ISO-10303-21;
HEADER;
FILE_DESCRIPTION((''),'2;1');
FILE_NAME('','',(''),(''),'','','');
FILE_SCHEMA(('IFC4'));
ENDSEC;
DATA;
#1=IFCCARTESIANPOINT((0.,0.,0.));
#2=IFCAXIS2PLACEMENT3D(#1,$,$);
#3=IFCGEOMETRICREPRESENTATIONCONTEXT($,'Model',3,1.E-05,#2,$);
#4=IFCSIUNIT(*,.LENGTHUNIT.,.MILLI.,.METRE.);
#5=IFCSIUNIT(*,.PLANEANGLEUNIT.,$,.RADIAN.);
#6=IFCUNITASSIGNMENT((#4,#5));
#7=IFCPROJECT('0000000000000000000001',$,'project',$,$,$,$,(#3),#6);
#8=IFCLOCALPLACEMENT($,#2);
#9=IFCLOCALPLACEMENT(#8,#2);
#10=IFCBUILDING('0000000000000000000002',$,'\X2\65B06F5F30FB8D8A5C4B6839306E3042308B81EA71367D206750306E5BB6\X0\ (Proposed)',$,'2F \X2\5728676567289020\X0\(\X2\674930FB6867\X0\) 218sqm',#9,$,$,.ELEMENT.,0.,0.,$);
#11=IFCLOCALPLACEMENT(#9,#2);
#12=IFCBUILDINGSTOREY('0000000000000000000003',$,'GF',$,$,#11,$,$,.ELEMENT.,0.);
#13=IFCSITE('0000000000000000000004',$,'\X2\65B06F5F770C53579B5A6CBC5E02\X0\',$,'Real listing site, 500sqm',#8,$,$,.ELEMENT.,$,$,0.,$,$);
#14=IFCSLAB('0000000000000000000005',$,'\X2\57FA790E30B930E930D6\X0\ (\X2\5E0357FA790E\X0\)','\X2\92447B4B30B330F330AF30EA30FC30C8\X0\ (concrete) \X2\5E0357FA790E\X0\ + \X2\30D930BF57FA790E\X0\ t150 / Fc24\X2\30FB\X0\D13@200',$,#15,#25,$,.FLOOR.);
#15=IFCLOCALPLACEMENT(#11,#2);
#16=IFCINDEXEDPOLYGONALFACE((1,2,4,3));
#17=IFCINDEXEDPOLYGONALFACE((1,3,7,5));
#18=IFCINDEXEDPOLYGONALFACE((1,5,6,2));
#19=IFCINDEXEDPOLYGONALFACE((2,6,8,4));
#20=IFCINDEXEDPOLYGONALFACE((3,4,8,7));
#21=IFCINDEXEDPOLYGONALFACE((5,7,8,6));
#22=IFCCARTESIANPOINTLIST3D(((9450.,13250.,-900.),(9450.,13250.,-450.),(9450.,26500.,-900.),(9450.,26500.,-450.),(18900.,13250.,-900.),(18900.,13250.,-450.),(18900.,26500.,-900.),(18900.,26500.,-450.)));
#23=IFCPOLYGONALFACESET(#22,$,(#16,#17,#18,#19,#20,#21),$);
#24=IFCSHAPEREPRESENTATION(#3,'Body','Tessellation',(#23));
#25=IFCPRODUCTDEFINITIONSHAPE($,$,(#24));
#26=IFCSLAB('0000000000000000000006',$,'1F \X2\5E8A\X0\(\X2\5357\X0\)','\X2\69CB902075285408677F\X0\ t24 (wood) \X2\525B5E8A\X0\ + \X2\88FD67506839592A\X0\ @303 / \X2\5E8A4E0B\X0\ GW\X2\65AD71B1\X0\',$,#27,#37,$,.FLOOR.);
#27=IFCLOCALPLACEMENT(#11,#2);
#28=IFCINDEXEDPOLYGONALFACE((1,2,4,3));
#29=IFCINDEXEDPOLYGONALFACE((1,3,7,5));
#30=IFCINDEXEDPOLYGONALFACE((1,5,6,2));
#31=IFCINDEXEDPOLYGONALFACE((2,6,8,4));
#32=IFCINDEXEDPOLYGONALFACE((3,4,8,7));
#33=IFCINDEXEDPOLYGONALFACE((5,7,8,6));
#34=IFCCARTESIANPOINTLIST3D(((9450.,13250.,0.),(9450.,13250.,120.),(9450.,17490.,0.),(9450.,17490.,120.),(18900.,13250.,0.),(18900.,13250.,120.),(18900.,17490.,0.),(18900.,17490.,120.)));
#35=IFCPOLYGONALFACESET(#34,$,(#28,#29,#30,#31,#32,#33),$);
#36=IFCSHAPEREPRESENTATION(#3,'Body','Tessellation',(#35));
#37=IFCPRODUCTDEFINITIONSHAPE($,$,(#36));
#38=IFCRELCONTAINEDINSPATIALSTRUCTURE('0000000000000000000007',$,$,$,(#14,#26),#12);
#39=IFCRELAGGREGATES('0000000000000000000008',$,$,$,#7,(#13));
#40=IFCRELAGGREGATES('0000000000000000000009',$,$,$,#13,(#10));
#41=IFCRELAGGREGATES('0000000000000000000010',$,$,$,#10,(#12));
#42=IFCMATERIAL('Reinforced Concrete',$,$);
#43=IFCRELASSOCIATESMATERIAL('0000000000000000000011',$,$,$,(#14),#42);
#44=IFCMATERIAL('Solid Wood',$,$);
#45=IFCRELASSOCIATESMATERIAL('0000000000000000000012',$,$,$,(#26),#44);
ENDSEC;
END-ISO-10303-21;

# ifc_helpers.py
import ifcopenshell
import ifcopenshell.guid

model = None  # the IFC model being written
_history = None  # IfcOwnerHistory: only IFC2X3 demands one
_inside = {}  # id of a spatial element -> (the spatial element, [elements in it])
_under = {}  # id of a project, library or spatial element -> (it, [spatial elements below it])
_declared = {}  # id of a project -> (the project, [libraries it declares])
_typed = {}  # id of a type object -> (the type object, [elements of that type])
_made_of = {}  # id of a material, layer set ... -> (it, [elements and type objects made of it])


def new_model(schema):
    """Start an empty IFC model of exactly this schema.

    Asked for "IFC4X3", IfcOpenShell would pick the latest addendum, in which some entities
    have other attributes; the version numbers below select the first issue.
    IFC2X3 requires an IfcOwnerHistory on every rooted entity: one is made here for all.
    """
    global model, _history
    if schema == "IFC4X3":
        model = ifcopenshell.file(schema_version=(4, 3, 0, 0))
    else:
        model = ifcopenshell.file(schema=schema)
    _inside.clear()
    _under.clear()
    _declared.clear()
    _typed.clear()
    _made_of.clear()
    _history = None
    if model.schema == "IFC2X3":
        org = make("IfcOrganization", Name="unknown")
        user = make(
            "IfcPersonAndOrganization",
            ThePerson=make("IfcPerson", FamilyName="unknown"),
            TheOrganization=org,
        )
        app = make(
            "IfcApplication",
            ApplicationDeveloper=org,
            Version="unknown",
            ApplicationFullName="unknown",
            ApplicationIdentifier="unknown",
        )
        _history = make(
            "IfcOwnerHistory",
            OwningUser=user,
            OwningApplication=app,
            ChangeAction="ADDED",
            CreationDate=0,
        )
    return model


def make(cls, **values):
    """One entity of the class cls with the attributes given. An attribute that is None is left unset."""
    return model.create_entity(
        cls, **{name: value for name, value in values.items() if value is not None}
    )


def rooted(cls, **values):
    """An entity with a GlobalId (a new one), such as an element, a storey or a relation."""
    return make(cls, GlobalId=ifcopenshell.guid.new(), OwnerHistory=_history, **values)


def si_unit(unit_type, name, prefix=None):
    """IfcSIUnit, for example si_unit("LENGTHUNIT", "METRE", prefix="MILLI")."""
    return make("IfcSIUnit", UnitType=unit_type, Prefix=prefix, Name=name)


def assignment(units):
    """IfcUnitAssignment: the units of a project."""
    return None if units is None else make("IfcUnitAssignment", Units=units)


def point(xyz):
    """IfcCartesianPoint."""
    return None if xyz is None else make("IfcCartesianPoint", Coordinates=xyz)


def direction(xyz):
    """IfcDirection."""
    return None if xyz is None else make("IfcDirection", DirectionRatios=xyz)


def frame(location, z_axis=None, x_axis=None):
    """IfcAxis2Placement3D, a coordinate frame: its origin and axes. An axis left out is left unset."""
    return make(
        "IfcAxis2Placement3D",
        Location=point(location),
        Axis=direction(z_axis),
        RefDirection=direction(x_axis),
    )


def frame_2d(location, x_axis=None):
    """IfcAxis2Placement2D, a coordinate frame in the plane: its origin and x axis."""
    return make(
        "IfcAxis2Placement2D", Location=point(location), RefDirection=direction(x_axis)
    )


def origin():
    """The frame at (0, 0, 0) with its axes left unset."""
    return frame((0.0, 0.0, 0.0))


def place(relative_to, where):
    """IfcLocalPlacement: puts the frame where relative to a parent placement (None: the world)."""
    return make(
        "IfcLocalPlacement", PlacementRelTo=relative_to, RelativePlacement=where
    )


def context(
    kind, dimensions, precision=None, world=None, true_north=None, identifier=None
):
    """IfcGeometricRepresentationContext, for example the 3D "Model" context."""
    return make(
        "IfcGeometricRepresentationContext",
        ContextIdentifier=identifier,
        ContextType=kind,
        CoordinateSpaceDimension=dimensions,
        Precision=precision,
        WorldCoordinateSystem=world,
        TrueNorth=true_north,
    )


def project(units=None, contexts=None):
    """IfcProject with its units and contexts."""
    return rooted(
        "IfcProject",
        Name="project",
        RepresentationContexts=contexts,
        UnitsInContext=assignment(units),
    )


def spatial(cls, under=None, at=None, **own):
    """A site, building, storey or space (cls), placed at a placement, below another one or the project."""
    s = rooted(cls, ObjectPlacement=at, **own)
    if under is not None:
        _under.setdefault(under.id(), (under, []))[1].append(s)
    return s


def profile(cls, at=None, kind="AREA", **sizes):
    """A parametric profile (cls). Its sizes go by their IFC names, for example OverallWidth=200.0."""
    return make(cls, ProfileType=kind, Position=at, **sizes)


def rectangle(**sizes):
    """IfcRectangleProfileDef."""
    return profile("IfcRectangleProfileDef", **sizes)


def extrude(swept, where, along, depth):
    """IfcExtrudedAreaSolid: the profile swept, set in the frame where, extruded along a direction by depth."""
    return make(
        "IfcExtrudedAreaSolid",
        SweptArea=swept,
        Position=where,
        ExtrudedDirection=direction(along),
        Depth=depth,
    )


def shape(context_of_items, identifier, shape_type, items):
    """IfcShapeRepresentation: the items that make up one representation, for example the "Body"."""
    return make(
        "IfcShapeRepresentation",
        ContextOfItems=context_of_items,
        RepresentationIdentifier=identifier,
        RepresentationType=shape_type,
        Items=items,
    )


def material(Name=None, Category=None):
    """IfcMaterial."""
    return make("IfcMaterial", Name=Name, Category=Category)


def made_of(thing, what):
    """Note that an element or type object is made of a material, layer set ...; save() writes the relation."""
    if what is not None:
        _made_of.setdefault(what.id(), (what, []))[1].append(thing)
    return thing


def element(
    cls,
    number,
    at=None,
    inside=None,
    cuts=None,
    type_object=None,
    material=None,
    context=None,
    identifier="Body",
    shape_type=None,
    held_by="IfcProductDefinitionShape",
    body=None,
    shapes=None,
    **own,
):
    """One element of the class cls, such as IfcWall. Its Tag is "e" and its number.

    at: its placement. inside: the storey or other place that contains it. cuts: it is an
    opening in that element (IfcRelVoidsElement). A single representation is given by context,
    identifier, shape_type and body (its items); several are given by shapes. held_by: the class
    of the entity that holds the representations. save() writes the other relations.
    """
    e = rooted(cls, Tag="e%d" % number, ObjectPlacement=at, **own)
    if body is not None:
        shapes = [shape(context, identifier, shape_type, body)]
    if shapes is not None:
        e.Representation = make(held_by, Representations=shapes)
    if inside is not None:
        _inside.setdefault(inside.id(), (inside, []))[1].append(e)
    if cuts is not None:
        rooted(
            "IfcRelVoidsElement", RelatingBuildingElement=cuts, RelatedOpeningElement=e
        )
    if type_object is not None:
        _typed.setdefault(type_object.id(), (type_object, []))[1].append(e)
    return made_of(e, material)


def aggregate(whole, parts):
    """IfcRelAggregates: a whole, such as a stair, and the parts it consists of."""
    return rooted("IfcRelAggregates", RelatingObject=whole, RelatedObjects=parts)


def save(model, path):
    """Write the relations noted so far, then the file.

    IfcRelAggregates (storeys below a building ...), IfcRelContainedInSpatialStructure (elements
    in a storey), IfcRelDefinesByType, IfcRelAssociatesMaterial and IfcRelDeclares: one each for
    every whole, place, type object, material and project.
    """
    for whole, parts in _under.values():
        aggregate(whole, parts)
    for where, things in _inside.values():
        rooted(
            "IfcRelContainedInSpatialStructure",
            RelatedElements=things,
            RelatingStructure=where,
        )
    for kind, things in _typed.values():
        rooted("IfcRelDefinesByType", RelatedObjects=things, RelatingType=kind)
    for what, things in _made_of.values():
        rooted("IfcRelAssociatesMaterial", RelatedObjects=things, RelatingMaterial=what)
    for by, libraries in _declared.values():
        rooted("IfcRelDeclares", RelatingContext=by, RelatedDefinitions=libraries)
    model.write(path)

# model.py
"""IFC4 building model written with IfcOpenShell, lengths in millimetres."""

from ifc_helpers import new_model, si_unit, frame, frame_2d, origin, place, context, project, spatial, rectangle, extrude, material, element, save


model = new_model("IFC4")

# Units and contexts
model_context = context("Model", 3, precision=1e-05, world=origin())
ifc_project = project(units=[si_unit("LENGTHUNIT", "METRE", prefix="MILLI"), si_unit("PLANEANGLEUNIT", "RADIAN")], contexts=[model_context])

# Site, building, storey
site_placement = place(None, origin())
site = spatial("IfcSite", under=ifc_project, at=site_placement, Name="新潟県南魚沼市", ObjectType="Real listing site, 500sqm", CompositionType="ELEMENT", RefElevation=0.0)
building_placement = place(site_placement, origin())
building = spatial("IfcBuilding", under=site, at=building_placement, Name="新潟・越屋根のある自然素材の家 (Proposed)", ObjectType="2F 在来木造(杉・桧) 218sqm", CompositionType="ELEMENT", ElevationOfRefHeight=0.0, ElevationOfTerrain=0.0)
storey_placement = place(building_placement, origin())
storey = spatial("IfcBuildingStorey", under=building, at=storey_placement, Name="GF", CompositionType="ELEMENT", Elevation=0.0)

# Shared definitions
ifc_material_1 = material(Name="Solid Wood")

# Slabs
ifc_material_2 = material(Name="Reinforced Concrete")
slab_1_placement = place(storey_placement, frame((4725.0, 6625.0, -450.0)))
element("IfcSlab", 1, at=slab_1_placement, inside=storey, material=ifc_material_2, Name="基礎スラブ (布基礎)", Description="鉄筋コンクリート (concrete) 布基礎 + ベタ基礎 t150 / Fc24・D13@200", PredefinedType="FLOOR", context=model_context, shape_type="SweptSolid", body=[
    extrude(rectangle(XDim=9450.0, YDim=13250.0, at=frame_2d((4725.0, 6625.0))), frame((4725.0, 6625.0, -450.0)), (0.0, 0.0, 1.0), 450.0),
])
slab_2_placement = place(storey_placement, frame((4725.0, 6625.0, 0.0)))
element("IfcSlab", 2, at=slab_2_placement, inside=storey, material=ifc_material_1, Name="1F 床(南)", Description="構造用合板 t24 (wood) 剛床 + 製材根太 @303 / 床下 GW断熱", PredefinedType="FLOOR", context=model_context, shape_type="SweptSolid", body=[
    extrude(rectangle(XDim=9450.0, YDim=4240.0, at=frame_2d((4725.0, 2120.0))), frame((4725.0, 6625.0, 0.0)), (0.0, 0.0, 1.0), 120.0),
])

save(model, "model.ifc")
